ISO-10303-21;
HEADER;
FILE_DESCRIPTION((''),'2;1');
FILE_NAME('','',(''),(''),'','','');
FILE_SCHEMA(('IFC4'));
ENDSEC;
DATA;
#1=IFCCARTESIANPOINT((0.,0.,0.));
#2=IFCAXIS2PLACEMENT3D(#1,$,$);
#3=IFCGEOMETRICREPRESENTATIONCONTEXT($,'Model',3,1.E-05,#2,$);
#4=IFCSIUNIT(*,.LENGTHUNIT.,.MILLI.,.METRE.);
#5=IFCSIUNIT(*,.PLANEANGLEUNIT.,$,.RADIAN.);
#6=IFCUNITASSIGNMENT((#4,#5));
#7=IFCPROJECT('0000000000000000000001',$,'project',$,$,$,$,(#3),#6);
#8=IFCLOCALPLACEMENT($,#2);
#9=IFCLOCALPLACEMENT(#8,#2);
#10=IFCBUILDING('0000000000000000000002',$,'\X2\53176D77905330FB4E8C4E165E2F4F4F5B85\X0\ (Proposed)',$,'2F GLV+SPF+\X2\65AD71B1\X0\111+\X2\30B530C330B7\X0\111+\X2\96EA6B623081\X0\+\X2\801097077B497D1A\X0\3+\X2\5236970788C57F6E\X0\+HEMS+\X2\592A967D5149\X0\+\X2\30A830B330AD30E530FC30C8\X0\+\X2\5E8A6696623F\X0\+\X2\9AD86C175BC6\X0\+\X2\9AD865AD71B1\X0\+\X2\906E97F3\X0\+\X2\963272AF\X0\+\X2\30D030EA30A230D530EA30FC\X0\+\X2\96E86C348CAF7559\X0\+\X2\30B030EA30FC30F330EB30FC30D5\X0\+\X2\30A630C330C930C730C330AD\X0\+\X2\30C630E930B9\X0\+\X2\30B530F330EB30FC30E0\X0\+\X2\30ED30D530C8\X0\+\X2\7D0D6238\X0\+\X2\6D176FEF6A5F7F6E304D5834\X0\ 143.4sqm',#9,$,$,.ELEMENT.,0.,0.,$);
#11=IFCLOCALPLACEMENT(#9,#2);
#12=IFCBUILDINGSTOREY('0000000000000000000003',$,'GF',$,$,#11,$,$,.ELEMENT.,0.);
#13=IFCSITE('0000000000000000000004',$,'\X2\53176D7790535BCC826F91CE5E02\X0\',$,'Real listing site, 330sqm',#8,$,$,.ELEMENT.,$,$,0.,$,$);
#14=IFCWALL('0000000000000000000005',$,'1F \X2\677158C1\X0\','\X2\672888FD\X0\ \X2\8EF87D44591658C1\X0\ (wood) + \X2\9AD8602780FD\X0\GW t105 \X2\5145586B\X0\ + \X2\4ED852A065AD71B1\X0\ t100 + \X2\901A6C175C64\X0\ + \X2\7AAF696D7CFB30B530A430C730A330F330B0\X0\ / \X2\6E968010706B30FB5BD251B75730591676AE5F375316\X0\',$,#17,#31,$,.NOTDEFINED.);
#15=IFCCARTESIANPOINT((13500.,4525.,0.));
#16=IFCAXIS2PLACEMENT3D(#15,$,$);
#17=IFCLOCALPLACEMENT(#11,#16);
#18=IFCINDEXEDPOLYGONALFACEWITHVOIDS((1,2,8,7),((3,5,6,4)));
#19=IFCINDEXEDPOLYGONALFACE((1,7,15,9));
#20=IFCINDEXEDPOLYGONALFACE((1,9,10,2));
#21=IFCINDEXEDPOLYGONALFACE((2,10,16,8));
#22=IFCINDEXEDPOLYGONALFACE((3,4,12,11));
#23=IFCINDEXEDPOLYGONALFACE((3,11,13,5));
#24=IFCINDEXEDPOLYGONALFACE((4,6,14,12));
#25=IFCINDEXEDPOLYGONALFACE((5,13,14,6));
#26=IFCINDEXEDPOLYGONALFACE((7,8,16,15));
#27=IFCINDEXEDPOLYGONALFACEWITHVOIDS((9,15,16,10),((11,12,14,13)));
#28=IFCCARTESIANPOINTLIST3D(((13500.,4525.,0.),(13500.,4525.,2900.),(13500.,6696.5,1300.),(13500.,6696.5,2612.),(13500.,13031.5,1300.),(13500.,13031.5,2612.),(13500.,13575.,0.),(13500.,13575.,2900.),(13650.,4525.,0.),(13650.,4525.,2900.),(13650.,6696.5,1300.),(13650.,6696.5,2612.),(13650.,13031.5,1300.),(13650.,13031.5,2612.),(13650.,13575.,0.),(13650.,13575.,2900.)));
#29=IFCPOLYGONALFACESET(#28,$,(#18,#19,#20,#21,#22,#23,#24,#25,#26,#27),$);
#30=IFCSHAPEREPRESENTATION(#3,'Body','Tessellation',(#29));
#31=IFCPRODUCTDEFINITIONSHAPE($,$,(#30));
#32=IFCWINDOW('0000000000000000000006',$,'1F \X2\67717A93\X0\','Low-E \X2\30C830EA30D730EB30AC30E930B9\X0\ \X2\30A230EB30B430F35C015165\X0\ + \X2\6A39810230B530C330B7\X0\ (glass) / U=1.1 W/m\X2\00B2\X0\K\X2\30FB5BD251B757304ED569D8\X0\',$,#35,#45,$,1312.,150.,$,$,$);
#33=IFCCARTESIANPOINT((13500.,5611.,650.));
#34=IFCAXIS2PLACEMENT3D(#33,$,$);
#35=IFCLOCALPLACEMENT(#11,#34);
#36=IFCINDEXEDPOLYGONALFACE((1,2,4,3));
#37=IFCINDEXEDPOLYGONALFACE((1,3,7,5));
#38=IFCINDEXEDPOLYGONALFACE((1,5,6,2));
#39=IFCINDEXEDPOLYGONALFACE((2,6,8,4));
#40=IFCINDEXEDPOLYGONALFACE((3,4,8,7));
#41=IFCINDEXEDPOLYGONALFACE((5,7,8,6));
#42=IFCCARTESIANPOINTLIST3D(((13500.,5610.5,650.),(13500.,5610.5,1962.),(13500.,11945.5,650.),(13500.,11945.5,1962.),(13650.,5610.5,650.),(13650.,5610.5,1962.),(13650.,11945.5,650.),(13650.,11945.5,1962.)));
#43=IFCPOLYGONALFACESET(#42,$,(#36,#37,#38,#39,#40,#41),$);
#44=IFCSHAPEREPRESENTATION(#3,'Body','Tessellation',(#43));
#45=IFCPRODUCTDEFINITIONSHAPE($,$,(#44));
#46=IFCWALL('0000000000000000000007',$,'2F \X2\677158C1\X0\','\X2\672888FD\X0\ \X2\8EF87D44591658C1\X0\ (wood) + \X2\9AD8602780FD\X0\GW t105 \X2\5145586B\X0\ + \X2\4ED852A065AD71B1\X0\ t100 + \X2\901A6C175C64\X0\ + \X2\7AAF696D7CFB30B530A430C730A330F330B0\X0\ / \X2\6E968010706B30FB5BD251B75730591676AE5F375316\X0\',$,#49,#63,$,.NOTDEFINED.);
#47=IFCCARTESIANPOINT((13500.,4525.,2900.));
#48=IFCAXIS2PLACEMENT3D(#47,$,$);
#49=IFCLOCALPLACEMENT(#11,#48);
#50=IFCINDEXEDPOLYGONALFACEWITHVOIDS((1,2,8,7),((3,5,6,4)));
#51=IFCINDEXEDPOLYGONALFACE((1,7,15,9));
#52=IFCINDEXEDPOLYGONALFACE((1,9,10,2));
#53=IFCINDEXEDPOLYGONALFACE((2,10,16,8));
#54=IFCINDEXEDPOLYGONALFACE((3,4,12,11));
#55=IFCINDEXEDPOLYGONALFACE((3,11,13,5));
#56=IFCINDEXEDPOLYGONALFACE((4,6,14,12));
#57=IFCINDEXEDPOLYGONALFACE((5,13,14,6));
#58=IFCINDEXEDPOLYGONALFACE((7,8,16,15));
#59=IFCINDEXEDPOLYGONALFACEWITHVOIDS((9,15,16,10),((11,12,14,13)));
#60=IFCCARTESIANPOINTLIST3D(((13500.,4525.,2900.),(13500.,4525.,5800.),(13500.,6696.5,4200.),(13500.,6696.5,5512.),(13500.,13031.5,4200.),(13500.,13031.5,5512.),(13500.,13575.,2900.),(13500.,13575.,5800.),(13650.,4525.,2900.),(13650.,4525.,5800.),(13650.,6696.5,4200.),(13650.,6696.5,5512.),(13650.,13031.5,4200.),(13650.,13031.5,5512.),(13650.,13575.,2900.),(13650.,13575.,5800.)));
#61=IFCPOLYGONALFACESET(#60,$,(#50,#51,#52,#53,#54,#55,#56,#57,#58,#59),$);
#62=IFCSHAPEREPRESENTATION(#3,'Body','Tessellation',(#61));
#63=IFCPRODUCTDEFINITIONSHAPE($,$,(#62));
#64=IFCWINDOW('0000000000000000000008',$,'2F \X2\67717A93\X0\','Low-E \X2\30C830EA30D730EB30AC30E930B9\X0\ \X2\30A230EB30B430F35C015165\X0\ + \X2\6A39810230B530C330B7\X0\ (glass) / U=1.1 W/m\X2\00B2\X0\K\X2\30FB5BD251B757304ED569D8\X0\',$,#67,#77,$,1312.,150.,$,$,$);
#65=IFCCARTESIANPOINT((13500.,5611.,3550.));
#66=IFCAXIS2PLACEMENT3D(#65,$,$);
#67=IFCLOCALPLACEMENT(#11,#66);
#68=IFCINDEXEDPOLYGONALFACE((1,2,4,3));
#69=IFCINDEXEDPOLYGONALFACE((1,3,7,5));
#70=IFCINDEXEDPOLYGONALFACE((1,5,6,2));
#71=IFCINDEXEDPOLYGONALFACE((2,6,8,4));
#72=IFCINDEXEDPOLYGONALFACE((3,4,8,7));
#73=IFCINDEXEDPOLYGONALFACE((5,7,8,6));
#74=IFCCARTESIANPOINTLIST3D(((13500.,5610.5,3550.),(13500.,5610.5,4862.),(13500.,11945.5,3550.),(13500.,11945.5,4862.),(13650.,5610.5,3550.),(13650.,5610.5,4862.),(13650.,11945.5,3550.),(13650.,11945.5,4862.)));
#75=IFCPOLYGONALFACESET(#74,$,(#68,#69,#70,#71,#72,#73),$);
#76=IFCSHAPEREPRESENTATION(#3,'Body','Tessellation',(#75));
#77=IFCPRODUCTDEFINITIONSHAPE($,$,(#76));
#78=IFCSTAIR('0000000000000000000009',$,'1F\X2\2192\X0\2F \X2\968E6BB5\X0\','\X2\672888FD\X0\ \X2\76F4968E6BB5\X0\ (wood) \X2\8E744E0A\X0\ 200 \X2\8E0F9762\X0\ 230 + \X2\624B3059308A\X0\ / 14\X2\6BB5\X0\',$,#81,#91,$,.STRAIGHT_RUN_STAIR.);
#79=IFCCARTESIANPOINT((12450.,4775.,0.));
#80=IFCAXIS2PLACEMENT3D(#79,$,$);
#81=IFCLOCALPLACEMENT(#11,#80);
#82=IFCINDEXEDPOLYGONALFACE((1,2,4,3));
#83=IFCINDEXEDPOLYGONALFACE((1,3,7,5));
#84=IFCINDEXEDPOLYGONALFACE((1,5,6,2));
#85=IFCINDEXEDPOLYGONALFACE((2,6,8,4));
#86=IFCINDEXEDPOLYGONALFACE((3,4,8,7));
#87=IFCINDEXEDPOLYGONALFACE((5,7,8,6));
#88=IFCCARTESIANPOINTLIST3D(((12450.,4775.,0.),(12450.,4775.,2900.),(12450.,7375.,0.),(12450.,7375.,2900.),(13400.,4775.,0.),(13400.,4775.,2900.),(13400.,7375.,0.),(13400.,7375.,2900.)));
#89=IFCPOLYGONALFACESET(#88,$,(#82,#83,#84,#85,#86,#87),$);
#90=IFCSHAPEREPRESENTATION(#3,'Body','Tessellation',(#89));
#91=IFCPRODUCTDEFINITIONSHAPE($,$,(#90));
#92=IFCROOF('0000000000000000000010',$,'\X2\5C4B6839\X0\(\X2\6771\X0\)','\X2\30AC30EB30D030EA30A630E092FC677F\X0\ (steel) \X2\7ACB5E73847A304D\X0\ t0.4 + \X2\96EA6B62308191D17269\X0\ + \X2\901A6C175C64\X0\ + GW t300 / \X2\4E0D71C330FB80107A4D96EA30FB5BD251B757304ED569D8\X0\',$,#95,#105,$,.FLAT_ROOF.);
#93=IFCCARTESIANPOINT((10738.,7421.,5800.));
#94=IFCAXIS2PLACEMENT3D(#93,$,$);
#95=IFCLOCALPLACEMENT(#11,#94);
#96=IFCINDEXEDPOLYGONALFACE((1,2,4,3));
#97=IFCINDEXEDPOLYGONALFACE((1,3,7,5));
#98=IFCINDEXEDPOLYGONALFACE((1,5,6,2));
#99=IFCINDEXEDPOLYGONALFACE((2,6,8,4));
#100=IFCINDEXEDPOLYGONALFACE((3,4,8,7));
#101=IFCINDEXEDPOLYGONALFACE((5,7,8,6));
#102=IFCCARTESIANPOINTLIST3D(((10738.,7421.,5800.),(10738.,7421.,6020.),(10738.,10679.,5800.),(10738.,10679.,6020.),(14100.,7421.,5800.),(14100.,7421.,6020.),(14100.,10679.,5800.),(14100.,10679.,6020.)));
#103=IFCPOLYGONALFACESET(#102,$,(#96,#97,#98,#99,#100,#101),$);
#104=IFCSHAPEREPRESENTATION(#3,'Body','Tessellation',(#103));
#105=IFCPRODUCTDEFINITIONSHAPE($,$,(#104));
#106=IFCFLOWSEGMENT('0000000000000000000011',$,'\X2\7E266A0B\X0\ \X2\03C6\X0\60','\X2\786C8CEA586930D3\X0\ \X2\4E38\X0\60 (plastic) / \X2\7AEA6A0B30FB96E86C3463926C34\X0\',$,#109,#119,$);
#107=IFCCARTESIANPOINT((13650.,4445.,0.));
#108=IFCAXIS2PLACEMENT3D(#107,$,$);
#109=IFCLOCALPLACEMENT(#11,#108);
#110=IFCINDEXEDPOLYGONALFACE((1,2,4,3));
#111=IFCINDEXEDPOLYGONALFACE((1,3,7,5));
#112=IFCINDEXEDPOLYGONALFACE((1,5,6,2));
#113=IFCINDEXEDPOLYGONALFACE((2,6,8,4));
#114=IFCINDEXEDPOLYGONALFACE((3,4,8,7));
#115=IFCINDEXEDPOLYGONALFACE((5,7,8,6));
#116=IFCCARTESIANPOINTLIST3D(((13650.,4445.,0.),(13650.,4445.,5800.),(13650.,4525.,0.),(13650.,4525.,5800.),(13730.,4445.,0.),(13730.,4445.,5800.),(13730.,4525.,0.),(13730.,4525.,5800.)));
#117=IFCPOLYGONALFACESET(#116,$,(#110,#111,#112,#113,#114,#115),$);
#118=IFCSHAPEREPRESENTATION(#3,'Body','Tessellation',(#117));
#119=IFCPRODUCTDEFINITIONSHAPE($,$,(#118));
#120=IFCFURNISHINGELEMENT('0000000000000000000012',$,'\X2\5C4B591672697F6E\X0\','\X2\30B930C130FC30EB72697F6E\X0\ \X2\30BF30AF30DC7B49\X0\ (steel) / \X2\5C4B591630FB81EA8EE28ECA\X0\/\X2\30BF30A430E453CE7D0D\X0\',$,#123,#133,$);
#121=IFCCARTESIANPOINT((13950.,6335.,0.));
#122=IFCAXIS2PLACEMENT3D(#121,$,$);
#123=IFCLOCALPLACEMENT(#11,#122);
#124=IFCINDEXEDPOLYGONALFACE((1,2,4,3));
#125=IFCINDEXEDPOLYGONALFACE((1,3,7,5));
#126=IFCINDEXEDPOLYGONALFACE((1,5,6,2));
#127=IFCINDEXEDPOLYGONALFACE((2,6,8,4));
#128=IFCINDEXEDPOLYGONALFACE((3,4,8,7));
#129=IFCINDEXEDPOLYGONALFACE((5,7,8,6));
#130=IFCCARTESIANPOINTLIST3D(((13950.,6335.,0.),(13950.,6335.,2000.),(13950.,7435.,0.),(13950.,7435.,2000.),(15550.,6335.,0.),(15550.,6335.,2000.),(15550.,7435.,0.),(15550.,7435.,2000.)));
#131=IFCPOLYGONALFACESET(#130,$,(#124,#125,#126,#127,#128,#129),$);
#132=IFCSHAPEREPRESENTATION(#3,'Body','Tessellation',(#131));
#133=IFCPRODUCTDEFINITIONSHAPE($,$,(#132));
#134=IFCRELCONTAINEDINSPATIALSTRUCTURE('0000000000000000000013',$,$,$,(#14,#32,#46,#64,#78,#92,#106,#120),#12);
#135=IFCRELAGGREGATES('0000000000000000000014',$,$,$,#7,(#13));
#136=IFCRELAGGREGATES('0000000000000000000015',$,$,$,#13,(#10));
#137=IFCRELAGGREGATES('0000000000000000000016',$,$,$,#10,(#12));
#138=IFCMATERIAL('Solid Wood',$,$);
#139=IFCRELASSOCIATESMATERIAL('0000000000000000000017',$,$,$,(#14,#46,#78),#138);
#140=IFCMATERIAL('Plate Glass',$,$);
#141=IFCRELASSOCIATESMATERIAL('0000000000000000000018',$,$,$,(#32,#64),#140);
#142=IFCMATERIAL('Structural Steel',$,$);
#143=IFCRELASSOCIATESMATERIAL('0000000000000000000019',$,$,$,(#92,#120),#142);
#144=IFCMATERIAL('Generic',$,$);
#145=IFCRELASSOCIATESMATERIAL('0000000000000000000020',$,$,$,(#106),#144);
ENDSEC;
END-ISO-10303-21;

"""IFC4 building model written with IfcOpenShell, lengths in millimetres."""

from ifc_helpers import new_model, si_unit, frame, frame_2d, origin, place, context, project, spatial, rectangle, extrude, material, element, fill, save


model = new_model("IFC4")

# Units and contexts
model_context = context("Model", 3, precision=1e-05, world=origin())
ifc_project = project(units=[si_unit("LENGTHUNIT", "METRE", prefix="MILLI"), si_unit("PLANEANGLEUNIT", "RADIAN")], contexts=[model_context])

# Site, building, storey
site_placement = place(None, origin())
site = spatial("IfcSite", under=ifc_project, at=site_placement, Name="北海道富良野市", ObjectType="Real listing site, 330sqm", CompositionType="ELEMENT", RefElevation=0.0)
building_placement = place(site_placement, origin())
building = spatial("IfcBuilding", under=site, at=building_placement, Name="北海道・二世帯住宅 (Proposed)", ObjectType="2F GLV+SPF+断熱111+サッシ111+雪止め+耐震等級3+制震装置+HEMS+太陽光+エコキュート+床暖房+高気密+高断熱+遮音+防犯+バリアフリー+雨水貯留+グリーンルーフ+ウッドデッキ+テラス+サンルーム+ロフト+納戸+洗濯機置き場 143.4sqm", CompositionType="ELEMENT", ElevationOfRefHeight=0.0, ElevationOfTerrain=0.0)
storey_placement = place(building_placement, origin())
storey = spatial("IfcBuildingStorey", under=building, at=storey_placement, Name="GF", CompositionType="ELEMENT", Elevation=0.0)

# Shared definitions
ifc_material_1 = material(Name="Solid Wood")

# Walls, openings, windows
wall_1_placement = place(storey_placement, frame((13500.0, 4525.0, 0.0)))
wall_1 = element("IfcWall", 1, at=wall_1_placement, inside=storey, material=ifc_material_1, Name="1F 東壁", Description="木製 軸組外壁 (wood) + 高性能GW t105 充填 + 付加断熱 t100 + 通気層 + 窯業系サイディング / 準耐火・寒冷地外皮強化", PredefinedType="NOTDEFINED", context=model_context, shape_type="SweptSolid", body=[
    extrude(rectangle(XDim=150.0, YDim=9050.0, at=frame_2d((75.0, 4525.0))), frame((13500.0, 4525.0, 0.0)), (0.0, 0.0, 1.0), 2900.0),
])
opening_1_placement = place(storey_placement, frame((13500.0, 5611.0, 650.0)))
opening_1 = element("IfcOpeningElement", 2, at=opening_1_placement, cuts=wall_1, PredefinedType="NOTDEFINED", context=model_context, shape_type="SweptSolid", body=[
    extrude(rectangle(XDim=150.0, YDim=6335.0, at=frame_2d((75.0, 3167.0))), frame((13500.0, 5611.0, 650.0)), (0.0, 0.0, 1.0), 1312.0),
])
ifc_material_2 = material(Name="Plate Glass")
window_1_placement = place(storey_placement, frame((13500.0, 5611.0, 650.0)))
window_1 = element("IfcWindow", 3, at=window_1_placement, inside=storey, material=ifc_material_2, Name="1F 東窓", Description="Low-E トリプルガラス アルゴン封入 + 樹脂サッシ (glass) / U=1.1 W/m²K・寒冷地仕様", OverallHeight=1312.0, OverallWidth=150.0, context=model_context, shape_type="SweptSolid", body=[
    extrude(rectangle(XDim=150.0, YDim=6335.0, at=frame_2d((75.0, 3167.0))), frame((13500.0, 5611.0, 650.0)), (0.0, 0.0, 1.0), 1312.0),
])
fill(opening_1, window_1)
wall_2_placement = place(storey_placement, frame((13500.0, 4525.0, 2900.0)))
wall_2 = element("IfcWall", 4, at=wall_2_placement, inside=storey, material=ifc_material_1, Name="2F 東壁", Description="木製 軸組外壁 (wood) + 高性能GW t105 充填 + 付加断熱 t100 + 通気層 + 窯業系サイディング / 準耐火・寒冷地外皮強化", PredefinedType="NOTDEFINED", context=model_context, shape_type="SweptSolid", body=[
    extrude(rectangle(XDim=150.0, YDim=9050.0, at=frame_2d((75.0, 4525.0))), frame((13500.0, 4525.0, 2900.0)), (0.0, 0.0, 1.0), 2900.0),
])
opening_2_placement = place(storey_placement, frame((13500.0, 5611.0, 3550.0)))
opening_2 = element("IfcOpeningElement", 5, at=opening_2_placement, cuts=wall_2, PredefinedType="NOTDEFINED", context=model_context, shape_type="SweptSolid", body=[
    extrude(rectangle(XDim=150.0, YDim=6335.0, at=frame_2d((75.0, 3167.0))), frame((13500.0, 5611.0, 3550.0)), (0.0, 0.0, 1.0), 1312.0),
])
window_2_placement = place(storey_placement, frame((13500.0, 5611.0, 3550.0)))
window_2 = element("IfcWindow", 6, at=window_2_placement, inside=storey, material=ifc_material_2, Name="2F 東窓", Description="Low-E トリプルガラス アルゴン封入 + 樹脂サッシ (glass) / U=1.1 W/m²K・寒冷地仕様", OverallHeight=1312.0, OverallWidth=150.0, context=model_context, shape_type="SweptSolid", body=[
    extrude(rectangle(XDim=150.0, YDim=6335.0, at=frame_2d((75.0, 3167.0))), frame((13500.0, 5611.0, 3550.0)), (0.0, 0.0, 1.0), 1312.0),
])
fill(opening_2, window_2)

# Stair
stair_placement = place(storey_placement, frame((12450.0, 4775.0, 0.0)))
element("IfcStair", 7, at=stair_placement, inside=storey, material=ifc_material_1, Name="1F→2F 階段", Description="木製 直階段 (wood) 蹴上 200 踏面 230 + 手すり / 14段", PredefinedType="STRAIGHT_RUN_STAIR", context=model_context, shape_type="SweptSolid", body=[
    extrude(rectangle(XDim=950.0, YDim=2600.0, at=frame_2d((475.0, 1300.0))), frame((12450.0, 4775.0, 0.0)), (0.0, 0.0, 1.0), 2900.0),
])

# Roof
ifc_material_3 = material(Name="Structural Steel")
roof_placement = place(storey_placement, frame((10738.0, 7421.0, 5800.0)))
element("IfcRoof", 8, at=roof_placement, inside=storey, material=ifc_material_3, Name="屋根(東)", Description="ガルバリウム鋼板 (steel) 立平葺き t0.4 + 雪止め金物 + 通気層 + GW t300 / 不燃・耐積雪・寒冷地仕様", PredefinedType="FLAT_ROOF", context=model_context, shape_type="SweptSolid", body=[
    extrude(rectangle(XDim=3362.0, YDim=3258.0, at=frame_2d((1681.0, 1629.0))), frame((10738.0, 7421.0, 5800.0)), (0.0, 0.0, 1.0), 220.0),
])

# Flow segment
ifc_material_4 = material(Name="Generic")
flow_segment_placement = place(storey_placement, frame((13650.0, 4445.0, 0.0)))
element("IfcFlowSegment", 9, at=flow_segment_placement, inside=storey, material=ifc_material_4, Name="縦樋 φ60", Description="硬質塩ビ 丸60 (plastic) / 竪樋・雨水排水", context=model_context, shape_type="SweptSolid", body=[
    extrude(rectangle(XDim=80.0, YDim=80.0, at=frame_2d((40.0, 40.0))), frame((13650.0, 4445.0, 0.0)), (0.0, 0.0, 1.0), 5800.0),
])

# Furnishing element
furnishing_placement = place(storey_placement, frame((13950.0, 6335.0, 0.0)))
element("IfcFurnishingElement", 10, at=furnishing_placement, inside=storey, material=ifc_material_3, Name="屋外物置", Description="スチール物置 タクボ等 (steel) / 屋外・自転車/タイヤ収納", context=model_context, shape_type="SweptSolid", body=[
    extrude(rectangle(XDim=1600.0, YDim=1100.0, at=frame_2d((800.0, 550.0))), frame((13950.0, 6335.0, 0.0)), (0.0, 0.0, 1.0), 2000.0),
])

save(model, "model.ifc")
